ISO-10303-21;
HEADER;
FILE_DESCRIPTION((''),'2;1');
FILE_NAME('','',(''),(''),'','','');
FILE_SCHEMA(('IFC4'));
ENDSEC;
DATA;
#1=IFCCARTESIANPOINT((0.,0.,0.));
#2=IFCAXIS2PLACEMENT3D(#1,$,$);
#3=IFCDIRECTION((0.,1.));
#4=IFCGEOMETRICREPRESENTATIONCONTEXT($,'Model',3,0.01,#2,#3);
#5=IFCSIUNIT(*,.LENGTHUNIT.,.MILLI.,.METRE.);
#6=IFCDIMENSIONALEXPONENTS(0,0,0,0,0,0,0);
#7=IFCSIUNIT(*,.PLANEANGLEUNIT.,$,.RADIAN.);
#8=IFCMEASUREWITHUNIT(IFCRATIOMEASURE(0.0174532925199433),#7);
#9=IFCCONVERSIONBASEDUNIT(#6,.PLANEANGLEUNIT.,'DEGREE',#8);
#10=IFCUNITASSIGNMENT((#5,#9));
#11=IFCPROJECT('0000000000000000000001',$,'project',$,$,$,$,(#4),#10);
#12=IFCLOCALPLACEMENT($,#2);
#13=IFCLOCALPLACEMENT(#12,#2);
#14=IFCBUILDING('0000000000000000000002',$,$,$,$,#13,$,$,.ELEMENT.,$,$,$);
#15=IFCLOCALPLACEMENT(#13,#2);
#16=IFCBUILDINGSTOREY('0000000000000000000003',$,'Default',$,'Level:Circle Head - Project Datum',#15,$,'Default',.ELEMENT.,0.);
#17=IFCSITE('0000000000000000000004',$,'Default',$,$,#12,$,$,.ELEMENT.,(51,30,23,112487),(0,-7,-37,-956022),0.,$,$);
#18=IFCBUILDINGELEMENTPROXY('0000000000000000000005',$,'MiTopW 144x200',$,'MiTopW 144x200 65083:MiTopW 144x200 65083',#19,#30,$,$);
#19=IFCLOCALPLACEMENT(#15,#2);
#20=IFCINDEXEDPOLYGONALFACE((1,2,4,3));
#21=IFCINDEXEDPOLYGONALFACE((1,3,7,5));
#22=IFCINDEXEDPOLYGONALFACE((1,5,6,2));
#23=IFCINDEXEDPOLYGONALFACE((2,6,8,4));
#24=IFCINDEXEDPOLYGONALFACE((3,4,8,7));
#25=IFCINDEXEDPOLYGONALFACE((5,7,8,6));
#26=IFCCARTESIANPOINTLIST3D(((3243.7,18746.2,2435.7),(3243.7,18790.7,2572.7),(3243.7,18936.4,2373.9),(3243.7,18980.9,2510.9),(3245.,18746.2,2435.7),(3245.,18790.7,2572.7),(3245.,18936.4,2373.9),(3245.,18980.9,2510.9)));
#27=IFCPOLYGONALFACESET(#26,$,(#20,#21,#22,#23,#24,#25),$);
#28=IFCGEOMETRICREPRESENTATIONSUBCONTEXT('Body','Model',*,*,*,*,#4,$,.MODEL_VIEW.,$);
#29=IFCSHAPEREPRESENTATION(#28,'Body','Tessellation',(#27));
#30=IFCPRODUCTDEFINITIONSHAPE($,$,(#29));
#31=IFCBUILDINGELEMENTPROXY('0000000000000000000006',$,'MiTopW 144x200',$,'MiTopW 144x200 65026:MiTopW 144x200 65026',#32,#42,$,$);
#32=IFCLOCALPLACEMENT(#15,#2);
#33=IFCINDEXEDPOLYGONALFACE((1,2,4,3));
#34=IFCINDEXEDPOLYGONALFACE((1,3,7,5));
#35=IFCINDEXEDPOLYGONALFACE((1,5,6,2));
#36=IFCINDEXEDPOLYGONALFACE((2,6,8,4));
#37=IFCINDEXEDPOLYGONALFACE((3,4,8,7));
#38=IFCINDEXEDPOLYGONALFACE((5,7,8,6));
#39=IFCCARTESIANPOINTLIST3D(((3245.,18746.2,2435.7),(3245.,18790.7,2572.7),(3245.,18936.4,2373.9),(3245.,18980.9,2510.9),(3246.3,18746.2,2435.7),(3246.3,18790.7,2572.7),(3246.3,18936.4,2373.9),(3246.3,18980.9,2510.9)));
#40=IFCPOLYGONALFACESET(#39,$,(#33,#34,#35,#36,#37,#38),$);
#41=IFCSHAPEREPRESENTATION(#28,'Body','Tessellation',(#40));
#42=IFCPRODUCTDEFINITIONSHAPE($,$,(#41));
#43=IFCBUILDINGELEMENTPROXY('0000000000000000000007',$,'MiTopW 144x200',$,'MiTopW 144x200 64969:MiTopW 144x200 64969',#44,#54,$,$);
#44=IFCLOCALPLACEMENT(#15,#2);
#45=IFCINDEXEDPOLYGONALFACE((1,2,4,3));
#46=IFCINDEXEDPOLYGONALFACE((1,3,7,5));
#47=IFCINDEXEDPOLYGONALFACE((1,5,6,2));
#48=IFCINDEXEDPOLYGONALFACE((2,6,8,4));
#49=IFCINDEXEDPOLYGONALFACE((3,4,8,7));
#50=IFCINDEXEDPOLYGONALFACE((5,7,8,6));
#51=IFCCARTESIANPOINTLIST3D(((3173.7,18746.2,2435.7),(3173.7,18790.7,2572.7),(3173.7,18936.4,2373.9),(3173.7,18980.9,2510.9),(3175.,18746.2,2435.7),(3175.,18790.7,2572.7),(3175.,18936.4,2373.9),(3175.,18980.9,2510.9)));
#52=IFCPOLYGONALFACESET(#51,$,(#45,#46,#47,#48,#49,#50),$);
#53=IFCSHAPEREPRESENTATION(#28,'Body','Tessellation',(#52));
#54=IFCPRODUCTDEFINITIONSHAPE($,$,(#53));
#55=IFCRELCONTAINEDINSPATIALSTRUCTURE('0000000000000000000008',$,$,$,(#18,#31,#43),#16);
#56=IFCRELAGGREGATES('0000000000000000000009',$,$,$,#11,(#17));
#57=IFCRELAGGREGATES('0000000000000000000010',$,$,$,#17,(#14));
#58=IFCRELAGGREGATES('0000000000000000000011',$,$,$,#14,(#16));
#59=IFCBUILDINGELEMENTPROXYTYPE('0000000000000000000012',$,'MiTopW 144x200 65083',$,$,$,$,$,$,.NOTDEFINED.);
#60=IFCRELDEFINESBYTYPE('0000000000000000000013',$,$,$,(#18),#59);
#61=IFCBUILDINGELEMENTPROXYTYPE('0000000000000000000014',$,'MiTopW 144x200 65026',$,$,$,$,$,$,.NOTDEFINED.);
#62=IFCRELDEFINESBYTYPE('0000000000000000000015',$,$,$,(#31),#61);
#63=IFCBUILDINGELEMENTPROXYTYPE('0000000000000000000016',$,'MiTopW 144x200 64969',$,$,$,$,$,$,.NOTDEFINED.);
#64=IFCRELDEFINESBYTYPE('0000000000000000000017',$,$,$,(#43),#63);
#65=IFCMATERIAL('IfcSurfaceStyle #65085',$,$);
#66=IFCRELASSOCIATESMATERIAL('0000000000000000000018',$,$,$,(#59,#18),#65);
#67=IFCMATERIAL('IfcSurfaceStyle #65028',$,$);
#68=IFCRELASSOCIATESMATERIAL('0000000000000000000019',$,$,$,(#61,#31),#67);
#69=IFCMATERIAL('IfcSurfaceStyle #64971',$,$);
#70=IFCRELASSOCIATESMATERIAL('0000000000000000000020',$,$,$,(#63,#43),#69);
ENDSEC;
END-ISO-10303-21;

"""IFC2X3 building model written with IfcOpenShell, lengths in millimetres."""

from ifc_helpers import new_model, entity, si_unit, converted_unit, direction, frame, origin, place, context, subcontext, project, spatial, polyline, outline, extrude, source, transform, mapped, material, type_object, type_shapes, element, save


model = new_model("IFC2X3")

# Units and contexts
model_context = context("Model", 3, precision=0.01, world=origin(), true_north=direction((0.0, 1.0)))
body_context = subcontext(model_context, "Body", "Model", "MODEL_VIEW")
ifc_project = project(units=[si_unit("LENGTHUNIT", "METRE", prefix="MILLI"), converted_unit("PLANEANGLEUNIT", "DEGREE", entity("IfcRatioMeasure", 0.0174532925199433), si_unit("PLANEANGLEUNIT", "RADIAN"), dimensions=[0, 0, 0, 0, 0, 0, 0])], contexts=[model_context])

# Site, building, storey
site_placement = place(None, origin())
site = spatial("IfcSite", under=ifc_project, at=site_placement, Name="Default", CompositionType="ELEMENT", RefLatitude=(51, 30, 23, 112487), RefLongitude=(0, -7, -37, -956022), RefElevation=0.0)
building_placement = place(site_placement, origin())
building = spatial("IfcBuilding", under=site, at=building_placement, CompositionType="ELEMENT")
storey_placement = place(building_placement, origin())
storey = spatial("IfcBuildingStorey", under=building, at=storey_placement, Name="Default", ObjectType="Level:Circle Head - Project Datum", LongName="Default", CompositionType="ELEMENT", Elevation=0.0)

# Building element proxies
ifc_material_1 = material(Name="IfcSurfaceStyle #65085")
building_element_proxy_type_1 = type_object("IfcBuildingElementProxyType", Name="MiTopW 144x200 65083", PredefinedType="NOTDEFINED", material=ifc_material_1)
shared_shape_1 = source(origin(), body_context, "Body", "SweptSolid", [
    extrude(outline(polyline([(-100.0, -72.0), (100.0, -72.0), (100.0, 72.0), (-100.0, 72.0), (-100.0, -72.0)])), frame((100.0, 72.0, 0.0), z_axis=(0.0, 0.0, 1.0), x_axis=(-1.0, 0.0, 0.0)), (0.0, 0.0, 1.0), 1.3),
])
type_shapes(building_element_proxy_type_1, [shared_shape_1])
proxy_1_placement = place(building_placement, frame((3245.0, 18936.4, 2373.9), z_axis=(-1.0, 0.0, 0.0), x_axis=(0.0, -0.951057, 0.309017)))
element("IfcBuildingElementProxy", 1, at=proxy_1_placement, inside=storey, type_object=building_element_proxy_type_1, material=ifc_material_1, Name="MiTopW 144x200", ObjectType="MiTopW 144x200 65083:MiTopW 144x200 65083", context=body_context, shape_type="MappedRepresentation", body=[
    mapped(shared_shape_1, transform((0.0, 0.0, 0.0), scale=1.0)),
])
ifc_material_2 = material(Name="IfcSurfaceStyle #65028")
building_element_proxy_type_2 = type_object("IfcBuildingElementProxyType", Name="MiTopW 144x200 65026", PredefinedType="NOTDEFINED", material=ifc_material_2)
shared_shape_2 = source(origin(), body_context, "Body", "SweptSolid", [
    extrude(outline(polyline([(-100.0, -72.0), (100.0, -72.0), (100.0, 72.0), (-100.0, 72.0), (-100.0, -72.0)])), frame((100.0, 72.0, 0.0), z_axis=(0.0, 0.0, 1.0), x_axis=(-1.0, 0.0, 0.0)), (0.0, 0.0, 1.0), 1.3),
])
type_shapes(building_element_proxy_type_2, [shared_shape_2])
proxy_2_placement = place(building_placement, frame((3246.3, 18936.4, 2373.9), z_axis=(-1.0, 0.0, 0.0), x_axis=(0.0, -0.951057, 0.309017)))
element("IfcBuildingElementProxy", 2, at=proxy_2_placement, inside=storey, type_object=building_element_proxy_type_2, material=ifc_material_2, Name="MiTopW 144x200", ObjectType="MiTopW 144x200 65026:MiTopW 144x200 65026", context=body_context, shape_type="MappedRepresentation", body=[
    mapped(shared_shape_2, transform((0.0, 0.0, 0.0), scale=1.0)),
])
ifc_material_3 = material(Name="IfcSurfaceStyle #64971")
building_element_proxy_type_3 = type_object("IfcBuildingElementProxyType", Name="MiTopW 144x200 64969", PredefinedType="NOTDEFINED", material=ifc_material_3)
shared_shape_3 = source(origin(), body_context, "Body", "SweptSolid", [
    extrude(outline(polyline([(-100.0, -72.0), (100.0, -72.0), (100.0, 72.0), (-100.0, 72.0), (-100.0, -72.0)])), frame((100.0, 72.0, 0.0), z_axis=(0.0, 0.0, 1.0), x_axis=(-1.0, 0.0, 0.0)), (0.0, 0.0, 1.0), 1.3),
])
type_shapes(building_element_proxy_type_3, [shared_shape_3])
proxy_3_placement = place(building_placement, frame((3175.0, 18936.4, 2373.9), z_axis=(-1.0, 0.0, 0.0), x_axis=(0.0, -0.951057, 0.309017)))
element("IfcBuildingElementProxy", 3, at=proxy_3_placement, inside=storey, type_object=building_element_proxy_type_3, material=ifc_material_3, Name="MiTopW 144x200", ObjectType="MiTopW 144x200 64969:MiTopW 144x200 64969", context=body_context, shape_type="MappedRepresentation", body=[
    mapped(shared_shape_3, transform((0.0, 0.0, 0.0), scale=1.0)),
])

save(model, "model.ifc")
